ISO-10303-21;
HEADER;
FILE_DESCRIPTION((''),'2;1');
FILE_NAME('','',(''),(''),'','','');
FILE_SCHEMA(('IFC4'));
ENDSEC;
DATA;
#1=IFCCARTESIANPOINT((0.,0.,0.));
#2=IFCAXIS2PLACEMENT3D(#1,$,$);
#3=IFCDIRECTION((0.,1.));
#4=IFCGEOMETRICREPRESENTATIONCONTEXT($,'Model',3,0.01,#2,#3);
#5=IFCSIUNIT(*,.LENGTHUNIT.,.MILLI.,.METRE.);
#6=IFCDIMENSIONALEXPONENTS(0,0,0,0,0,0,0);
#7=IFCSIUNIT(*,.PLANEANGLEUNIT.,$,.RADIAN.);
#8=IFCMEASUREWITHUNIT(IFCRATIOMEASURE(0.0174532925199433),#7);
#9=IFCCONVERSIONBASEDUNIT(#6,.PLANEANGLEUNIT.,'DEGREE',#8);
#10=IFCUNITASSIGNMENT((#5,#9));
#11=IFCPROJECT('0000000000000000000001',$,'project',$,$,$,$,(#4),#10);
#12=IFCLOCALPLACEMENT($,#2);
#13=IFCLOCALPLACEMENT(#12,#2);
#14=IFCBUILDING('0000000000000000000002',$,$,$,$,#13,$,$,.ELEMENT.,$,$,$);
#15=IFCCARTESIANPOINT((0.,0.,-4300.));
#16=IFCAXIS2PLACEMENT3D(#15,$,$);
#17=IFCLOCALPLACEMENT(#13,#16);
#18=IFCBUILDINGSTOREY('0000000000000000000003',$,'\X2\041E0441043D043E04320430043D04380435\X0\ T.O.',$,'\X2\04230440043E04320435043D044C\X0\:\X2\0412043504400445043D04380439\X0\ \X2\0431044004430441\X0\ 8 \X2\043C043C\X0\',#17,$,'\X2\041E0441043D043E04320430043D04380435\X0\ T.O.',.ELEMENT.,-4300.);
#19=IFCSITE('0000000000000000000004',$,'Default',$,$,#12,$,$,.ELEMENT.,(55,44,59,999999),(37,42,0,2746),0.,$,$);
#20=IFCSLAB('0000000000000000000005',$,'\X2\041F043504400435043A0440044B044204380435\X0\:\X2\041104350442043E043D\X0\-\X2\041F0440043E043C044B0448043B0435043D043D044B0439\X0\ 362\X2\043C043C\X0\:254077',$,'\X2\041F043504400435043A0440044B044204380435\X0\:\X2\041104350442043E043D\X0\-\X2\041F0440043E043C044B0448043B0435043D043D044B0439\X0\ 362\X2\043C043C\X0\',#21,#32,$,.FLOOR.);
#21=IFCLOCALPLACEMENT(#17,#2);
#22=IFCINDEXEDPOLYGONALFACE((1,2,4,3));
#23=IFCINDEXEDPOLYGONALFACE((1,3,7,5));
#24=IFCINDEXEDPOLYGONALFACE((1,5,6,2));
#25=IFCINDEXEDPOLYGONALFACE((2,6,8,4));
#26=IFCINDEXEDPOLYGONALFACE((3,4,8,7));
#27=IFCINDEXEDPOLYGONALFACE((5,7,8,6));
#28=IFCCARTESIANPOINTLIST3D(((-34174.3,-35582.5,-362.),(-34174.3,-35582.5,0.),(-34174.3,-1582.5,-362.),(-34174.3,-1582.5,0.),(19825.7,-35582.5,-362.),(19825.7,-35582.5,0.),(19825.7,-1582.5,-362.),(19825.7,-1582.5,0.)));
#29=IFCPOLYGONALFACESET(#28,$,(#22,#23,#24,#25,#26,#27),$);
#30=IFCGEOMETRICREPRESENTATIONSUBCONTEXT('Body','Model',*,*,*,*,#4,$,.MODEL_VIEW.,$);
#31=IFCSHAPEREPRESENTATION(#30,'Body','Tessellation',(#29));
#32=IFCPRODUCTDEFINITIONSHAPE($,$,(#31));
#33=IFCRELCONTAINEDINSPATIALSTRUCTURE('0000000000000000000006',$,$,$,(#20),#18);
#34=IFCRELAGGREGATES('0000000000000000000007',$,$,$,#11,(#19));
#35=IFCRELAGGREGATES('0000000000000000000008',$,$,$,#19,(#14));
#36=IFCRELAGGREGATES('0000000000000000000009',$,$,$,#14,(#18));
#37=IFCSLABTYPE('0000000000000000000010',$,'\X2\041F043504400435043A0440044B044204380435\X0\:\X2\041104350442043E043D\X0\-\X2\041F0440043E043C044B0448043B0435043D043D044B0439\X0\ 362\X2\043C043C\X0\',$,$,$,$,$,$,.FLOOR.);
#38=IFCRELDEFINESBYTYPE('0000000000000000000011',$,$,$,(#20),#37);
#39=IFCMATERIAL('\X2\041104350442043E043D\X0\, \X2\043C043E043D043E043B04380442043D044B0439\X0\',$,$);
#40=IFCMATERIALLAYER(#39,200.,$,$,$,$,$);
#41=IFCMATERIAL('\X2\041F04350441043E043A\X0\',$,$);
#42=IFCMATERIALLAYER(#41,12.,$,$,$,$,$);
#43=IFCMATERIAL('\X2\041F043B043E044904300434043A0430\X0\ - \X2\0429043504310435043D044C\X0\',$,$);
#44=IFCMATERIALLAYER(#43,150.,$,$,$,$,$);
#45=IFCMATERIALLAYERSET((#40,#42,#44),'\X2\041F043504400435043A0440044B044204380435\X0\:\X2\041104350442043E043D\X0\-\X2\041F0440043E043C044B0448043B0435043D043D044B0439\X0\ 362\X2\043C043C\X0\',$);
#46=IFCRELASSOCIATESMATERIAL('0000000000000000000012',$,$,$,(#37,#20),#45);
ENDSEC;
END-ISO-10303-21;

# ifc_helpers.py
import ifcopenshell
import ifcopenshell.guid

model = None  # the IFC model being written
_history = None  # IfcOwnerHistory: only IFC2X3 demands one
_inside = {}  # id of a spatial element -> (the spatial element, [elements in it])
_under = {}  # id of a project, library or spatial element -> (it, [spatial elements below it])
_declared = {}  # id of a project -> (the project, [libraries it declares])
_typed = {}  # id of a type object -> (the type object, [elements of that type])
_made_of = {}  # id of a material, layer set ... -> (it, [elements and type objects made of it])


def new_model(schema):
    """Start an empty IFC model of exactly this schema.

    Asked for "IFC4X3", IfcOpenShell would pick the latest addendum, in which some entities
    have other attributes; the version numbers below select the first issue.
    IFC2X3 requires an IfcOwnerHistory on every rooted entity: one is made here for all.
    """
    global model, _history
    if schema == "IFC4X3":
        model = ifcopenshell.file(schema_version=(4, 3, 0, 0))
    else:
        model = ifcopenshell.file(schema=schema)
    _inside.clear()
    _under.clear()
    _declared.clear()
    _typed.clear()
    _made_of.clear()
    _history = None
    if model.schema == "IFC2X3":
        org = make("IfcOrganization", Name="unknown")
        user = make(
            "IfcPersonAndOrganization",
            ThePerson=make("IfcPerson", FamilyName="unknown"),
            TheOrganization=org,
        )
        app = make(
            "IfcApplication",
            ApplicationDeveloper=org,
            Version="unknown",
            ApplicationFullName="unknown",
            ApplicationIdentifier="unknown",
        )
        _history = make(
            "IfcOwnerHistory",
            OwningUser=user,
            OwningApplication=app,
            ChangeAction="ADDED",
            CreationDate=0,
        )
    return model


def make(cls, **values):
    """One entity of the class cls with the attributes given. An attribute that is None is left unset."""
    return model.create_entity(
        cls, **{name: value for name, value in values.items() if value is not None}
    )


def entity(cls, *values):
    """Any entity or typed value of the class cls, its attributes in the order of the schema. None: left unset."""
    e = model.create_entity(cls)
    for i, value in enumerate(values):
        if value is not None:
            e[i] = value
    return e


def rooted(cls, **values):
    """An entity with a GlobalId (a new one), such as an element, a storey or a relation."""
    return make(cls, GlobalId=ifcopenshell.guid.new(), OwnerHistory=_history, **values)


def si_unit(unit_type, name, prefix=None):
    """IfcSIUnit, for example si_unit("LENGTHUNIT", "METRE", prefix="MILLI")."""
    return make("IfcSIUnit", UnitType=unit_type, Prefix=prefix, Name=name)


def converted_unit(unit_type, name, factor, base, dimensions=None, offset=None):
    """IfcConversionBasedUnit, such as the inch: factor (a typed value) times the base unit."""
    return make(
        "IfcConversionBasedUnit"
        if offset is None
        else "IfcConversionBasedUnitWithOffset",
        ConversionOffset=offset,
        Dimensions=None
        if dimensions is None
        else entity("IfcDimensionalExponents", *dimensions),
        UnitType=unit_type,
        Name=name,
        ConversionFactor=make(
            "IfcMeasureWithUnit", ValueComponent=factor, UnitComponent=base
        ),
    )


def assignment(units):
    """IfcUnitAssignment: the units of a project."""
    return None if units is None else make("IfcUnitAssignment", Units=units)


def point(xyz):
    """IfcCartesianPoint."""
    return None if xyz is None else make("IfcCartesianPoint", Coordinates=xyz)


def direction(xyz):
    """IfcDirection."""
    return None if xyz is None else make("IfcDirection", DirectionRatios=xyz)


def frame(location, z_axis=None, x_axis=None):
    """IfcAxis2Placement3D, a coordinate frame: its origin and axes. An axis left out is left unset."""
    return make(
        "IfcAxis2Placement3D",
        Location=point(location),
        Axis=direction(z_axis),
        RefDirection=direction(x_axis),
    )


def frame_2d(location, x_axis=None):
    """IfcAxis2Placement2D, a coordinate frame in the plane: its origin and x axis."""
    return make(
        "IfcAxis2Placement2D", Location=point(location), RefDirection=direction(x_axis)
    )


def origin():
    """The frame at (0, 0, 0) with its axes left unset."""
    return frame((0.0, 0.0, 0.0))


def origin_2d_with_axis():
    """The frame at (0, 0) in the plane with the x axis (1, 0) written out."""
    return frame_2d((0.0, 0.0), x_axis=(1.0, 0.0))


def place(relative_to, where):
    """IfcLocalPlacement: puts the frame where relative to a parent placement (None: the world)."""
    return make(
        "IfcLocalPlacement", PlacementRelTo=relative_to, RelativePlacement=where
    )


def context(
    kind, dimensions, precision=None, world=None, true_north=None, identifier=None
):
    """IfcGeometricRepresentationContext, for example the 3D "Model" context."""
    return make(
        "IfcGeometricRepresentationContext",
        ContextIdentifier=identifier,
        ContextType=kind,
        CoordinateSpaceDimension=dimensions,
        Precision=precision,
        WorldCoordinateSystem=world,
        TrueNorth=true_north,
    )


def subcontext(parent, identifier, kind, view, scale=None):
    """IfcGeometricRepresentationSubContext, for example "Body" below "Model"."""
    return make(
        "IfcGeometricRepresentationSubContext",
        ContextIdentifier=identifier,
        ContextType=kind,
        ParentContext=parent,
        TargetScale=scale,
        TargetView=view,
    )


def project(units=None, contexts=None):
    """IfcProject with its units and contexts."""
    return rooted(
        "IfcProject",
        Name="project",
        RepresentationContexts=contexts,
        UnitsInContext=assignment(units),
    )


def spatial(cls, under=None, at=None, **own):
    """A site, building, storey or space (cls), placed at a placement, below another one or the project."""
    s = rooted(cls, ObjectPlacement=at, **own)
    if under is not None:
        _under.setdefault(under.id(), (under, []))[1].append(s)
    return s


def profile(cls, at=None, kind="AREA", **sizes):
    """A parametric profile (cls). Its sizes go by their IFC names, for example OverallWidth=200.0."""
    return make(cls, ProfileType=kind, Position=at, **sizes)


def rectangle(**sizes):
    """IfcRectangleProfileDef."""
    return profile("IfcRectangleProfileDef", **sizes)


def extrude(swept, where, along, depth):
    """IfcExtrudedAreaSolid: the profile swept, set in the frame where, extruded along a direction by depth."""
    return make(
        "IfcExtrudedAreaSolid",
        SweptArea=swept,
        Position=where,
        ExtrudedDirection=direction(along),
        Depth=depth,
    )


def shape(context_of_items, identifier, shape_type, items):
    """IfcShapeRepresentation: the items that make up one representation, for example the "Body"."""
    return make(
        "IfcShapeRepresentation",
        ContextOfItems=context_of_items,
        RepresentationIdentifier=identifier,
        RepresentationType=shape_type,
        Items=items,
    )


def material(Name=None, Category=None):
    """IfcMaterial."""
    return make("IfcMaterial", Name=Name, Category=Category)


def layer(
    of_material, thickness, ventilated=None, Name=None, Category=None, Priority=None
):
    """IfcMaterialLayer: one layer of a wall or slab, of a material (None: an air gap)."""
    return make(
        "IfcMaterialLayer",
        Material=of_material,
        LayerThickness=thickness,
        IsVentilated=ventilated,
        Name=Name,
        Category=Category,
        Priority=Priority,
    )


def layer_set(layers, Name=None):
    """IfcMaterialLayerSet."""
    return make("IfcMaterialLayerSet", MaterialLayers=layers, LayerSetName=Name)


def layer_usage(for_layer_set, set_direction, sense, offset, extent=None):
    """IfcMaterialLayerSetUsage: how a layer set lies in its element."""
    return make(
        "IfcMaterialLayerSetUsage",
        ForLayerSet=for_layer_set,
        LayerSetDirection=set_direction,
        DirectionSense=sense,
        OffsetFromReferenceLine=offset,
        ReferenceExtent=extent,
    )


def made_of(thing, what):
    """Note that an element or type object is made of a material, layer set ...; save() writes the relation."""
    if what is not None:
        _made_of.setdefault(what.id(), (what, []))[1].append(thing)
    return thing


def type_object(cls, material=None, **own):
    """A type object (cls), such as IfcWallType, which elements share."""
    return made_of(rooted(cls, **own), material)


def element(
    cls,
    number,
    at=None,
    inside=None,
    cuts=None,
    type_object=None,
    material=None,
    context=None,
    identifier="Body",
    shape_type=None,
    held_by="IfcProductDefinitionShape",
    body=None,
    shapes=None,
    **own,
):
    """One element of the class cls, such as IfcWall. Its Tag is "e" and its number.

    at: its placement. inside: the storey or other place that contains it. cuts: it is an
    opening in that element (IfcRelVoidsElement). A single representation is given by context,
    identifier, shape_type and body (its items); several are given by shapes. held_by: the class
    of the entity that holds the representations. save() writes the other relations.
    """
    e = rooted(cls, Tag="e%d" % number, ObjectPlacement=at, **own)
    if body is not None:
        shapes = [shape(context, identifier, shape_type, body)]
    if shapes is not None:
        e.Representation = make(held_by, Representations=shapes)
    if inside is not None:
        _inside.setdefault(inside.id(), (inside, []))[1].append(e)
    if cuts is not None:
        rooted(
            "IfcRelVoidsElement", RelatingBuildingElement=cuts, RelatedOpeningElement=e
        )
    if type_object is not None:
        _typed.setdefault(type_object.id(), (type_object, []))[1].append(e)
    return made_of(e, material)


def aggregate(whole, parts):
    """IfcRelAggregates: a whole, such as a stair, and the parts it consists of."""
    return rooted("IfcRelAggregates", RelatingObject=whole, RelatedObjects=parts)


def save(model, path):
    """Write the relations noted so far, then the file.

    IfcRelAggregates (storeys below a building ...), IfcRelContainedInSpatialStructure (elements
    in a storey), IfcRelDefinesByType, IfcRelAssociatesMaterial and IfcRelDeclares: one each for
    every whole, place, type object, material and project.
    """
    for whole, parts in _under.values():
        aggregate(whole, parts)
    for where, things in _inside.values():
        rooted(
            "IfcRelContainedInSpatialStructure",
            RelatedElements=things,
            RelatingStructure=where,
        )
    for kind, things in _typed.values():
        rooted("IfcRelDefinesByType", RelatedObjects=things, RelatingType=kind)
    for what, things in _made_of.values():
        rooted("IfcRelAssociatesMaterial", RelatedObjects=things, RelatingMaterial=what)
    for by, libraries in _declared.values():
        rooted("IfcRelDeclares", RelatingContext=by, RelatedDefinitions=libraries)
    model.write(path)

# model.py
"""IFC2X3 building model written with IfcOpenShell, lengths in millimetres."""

from ifc_helpers import new_model, entity, si_unit, converted_unit, direction, frame, origin, origin_2d_with_axis, place, context, subcontext, project, spatial, rectangle, extrude, material, layer, layer_set, layer_usage, type_object, element, save


model = new_model("IFC2X3")

# Units and contexts
model_context = context("Model", 3, precision=0.01, world=origin(), true_north=direction((0.0, 1.0)))
body_context = subcontext(model_context, "Body", "Model", "MODEL_VIEW")
ifc_project = project(units=[si_unit("LENGTHUNIT", "METRE", prefix="MILLI"), converted_unit("PLANEANGLEUNIT", "DEGREE", entity("IfcRatioMeasure", 0.0174532925199433), si_unit("PLANEANGLEUNIT", "RADIAN"), dimensions=[0, 0, 0, 0, 0, 0, 0])], contexts=[model_context])

# Site, building, storey
site_placement = place(None, origin())
site = spatial("IfcSite", under=ifc_project, at=site_placement, Name="Default", CompositionType="ELEMENT", RefLatitude=(55, 44, 59, 999999), RefLongitude=(37, 42, 0, 2746), RefElevation=0.0)
building_placement = place(site_placement, origin())
building = spatial("IfcBuilding", under=site, at=building_placement, CompositionType="ELEMENT")
storey_placement = place(building_placement, frame((0.0, 0.0, -4300.0)))
storey = spatial("IfcBuildingStorey", under=building, at=storey_placement, Name="Основание T.O.", ObjectType="Уровень:Верхний брус 8 мм", LongName="Основание T.O.", CompositionType="ELEMENT", Elevation=-4300.0)

# Slab
ifc_material_1 = material(Name="Бетон, монолитный")
ifc_layer_1 = layer(ifc_material_1, 200.0)
ifc_material_2 = material(Name="Песок")
ifc_layer_2 = layer(ifc_material_2, 12.0)
ifc_material_3 = material(Name="Площадка - Щебень")
ifc_layer_3 = layer(ifc_material_3, 150.0)
ifc_layer_set = layer_set([ifc_layer_1, ifc_layer_2, ifc_layer_3], Name="Перекрытие:Бетон-Промышленный 362мм")
ifc_layer_usage = layer_usage(ifc_layer_set, "AXIS3", "POSITIVE", 0.0)
slab_type = type_object("IfcSlabType", Name="Перекрытие:Бетон-Промышленный 362мм", PredefinedType="FLOOR", material=ifc_layer_set)
slab_placement = place(storey_placement, origin())
element("IfcSlab", 1, at=slab_placement, inside=storey, type_object=slab_type, material=ifc_layer_usage, Name="Перекрытие:Бетон-Промышленный 362мм:254077", ObjectType="Перекрытие:Бетон-Промышленный 362мм", PredefinedType="FLOOR", context=body_context, shape_type="SweptSolid", body=[
    extrude(rectangle(XDim=34000.0, YDim=54000.0, at=origin_2d_with_axis()), frame((-7174.3, -18582.5, 0.0), z_axis=(0.0, 0.0, -1.0), x_axis=(0.0, 1.0, 0.0)), (0.0, 0.0, 1.0), 362.0),
])

save(model, "model.ifc")
